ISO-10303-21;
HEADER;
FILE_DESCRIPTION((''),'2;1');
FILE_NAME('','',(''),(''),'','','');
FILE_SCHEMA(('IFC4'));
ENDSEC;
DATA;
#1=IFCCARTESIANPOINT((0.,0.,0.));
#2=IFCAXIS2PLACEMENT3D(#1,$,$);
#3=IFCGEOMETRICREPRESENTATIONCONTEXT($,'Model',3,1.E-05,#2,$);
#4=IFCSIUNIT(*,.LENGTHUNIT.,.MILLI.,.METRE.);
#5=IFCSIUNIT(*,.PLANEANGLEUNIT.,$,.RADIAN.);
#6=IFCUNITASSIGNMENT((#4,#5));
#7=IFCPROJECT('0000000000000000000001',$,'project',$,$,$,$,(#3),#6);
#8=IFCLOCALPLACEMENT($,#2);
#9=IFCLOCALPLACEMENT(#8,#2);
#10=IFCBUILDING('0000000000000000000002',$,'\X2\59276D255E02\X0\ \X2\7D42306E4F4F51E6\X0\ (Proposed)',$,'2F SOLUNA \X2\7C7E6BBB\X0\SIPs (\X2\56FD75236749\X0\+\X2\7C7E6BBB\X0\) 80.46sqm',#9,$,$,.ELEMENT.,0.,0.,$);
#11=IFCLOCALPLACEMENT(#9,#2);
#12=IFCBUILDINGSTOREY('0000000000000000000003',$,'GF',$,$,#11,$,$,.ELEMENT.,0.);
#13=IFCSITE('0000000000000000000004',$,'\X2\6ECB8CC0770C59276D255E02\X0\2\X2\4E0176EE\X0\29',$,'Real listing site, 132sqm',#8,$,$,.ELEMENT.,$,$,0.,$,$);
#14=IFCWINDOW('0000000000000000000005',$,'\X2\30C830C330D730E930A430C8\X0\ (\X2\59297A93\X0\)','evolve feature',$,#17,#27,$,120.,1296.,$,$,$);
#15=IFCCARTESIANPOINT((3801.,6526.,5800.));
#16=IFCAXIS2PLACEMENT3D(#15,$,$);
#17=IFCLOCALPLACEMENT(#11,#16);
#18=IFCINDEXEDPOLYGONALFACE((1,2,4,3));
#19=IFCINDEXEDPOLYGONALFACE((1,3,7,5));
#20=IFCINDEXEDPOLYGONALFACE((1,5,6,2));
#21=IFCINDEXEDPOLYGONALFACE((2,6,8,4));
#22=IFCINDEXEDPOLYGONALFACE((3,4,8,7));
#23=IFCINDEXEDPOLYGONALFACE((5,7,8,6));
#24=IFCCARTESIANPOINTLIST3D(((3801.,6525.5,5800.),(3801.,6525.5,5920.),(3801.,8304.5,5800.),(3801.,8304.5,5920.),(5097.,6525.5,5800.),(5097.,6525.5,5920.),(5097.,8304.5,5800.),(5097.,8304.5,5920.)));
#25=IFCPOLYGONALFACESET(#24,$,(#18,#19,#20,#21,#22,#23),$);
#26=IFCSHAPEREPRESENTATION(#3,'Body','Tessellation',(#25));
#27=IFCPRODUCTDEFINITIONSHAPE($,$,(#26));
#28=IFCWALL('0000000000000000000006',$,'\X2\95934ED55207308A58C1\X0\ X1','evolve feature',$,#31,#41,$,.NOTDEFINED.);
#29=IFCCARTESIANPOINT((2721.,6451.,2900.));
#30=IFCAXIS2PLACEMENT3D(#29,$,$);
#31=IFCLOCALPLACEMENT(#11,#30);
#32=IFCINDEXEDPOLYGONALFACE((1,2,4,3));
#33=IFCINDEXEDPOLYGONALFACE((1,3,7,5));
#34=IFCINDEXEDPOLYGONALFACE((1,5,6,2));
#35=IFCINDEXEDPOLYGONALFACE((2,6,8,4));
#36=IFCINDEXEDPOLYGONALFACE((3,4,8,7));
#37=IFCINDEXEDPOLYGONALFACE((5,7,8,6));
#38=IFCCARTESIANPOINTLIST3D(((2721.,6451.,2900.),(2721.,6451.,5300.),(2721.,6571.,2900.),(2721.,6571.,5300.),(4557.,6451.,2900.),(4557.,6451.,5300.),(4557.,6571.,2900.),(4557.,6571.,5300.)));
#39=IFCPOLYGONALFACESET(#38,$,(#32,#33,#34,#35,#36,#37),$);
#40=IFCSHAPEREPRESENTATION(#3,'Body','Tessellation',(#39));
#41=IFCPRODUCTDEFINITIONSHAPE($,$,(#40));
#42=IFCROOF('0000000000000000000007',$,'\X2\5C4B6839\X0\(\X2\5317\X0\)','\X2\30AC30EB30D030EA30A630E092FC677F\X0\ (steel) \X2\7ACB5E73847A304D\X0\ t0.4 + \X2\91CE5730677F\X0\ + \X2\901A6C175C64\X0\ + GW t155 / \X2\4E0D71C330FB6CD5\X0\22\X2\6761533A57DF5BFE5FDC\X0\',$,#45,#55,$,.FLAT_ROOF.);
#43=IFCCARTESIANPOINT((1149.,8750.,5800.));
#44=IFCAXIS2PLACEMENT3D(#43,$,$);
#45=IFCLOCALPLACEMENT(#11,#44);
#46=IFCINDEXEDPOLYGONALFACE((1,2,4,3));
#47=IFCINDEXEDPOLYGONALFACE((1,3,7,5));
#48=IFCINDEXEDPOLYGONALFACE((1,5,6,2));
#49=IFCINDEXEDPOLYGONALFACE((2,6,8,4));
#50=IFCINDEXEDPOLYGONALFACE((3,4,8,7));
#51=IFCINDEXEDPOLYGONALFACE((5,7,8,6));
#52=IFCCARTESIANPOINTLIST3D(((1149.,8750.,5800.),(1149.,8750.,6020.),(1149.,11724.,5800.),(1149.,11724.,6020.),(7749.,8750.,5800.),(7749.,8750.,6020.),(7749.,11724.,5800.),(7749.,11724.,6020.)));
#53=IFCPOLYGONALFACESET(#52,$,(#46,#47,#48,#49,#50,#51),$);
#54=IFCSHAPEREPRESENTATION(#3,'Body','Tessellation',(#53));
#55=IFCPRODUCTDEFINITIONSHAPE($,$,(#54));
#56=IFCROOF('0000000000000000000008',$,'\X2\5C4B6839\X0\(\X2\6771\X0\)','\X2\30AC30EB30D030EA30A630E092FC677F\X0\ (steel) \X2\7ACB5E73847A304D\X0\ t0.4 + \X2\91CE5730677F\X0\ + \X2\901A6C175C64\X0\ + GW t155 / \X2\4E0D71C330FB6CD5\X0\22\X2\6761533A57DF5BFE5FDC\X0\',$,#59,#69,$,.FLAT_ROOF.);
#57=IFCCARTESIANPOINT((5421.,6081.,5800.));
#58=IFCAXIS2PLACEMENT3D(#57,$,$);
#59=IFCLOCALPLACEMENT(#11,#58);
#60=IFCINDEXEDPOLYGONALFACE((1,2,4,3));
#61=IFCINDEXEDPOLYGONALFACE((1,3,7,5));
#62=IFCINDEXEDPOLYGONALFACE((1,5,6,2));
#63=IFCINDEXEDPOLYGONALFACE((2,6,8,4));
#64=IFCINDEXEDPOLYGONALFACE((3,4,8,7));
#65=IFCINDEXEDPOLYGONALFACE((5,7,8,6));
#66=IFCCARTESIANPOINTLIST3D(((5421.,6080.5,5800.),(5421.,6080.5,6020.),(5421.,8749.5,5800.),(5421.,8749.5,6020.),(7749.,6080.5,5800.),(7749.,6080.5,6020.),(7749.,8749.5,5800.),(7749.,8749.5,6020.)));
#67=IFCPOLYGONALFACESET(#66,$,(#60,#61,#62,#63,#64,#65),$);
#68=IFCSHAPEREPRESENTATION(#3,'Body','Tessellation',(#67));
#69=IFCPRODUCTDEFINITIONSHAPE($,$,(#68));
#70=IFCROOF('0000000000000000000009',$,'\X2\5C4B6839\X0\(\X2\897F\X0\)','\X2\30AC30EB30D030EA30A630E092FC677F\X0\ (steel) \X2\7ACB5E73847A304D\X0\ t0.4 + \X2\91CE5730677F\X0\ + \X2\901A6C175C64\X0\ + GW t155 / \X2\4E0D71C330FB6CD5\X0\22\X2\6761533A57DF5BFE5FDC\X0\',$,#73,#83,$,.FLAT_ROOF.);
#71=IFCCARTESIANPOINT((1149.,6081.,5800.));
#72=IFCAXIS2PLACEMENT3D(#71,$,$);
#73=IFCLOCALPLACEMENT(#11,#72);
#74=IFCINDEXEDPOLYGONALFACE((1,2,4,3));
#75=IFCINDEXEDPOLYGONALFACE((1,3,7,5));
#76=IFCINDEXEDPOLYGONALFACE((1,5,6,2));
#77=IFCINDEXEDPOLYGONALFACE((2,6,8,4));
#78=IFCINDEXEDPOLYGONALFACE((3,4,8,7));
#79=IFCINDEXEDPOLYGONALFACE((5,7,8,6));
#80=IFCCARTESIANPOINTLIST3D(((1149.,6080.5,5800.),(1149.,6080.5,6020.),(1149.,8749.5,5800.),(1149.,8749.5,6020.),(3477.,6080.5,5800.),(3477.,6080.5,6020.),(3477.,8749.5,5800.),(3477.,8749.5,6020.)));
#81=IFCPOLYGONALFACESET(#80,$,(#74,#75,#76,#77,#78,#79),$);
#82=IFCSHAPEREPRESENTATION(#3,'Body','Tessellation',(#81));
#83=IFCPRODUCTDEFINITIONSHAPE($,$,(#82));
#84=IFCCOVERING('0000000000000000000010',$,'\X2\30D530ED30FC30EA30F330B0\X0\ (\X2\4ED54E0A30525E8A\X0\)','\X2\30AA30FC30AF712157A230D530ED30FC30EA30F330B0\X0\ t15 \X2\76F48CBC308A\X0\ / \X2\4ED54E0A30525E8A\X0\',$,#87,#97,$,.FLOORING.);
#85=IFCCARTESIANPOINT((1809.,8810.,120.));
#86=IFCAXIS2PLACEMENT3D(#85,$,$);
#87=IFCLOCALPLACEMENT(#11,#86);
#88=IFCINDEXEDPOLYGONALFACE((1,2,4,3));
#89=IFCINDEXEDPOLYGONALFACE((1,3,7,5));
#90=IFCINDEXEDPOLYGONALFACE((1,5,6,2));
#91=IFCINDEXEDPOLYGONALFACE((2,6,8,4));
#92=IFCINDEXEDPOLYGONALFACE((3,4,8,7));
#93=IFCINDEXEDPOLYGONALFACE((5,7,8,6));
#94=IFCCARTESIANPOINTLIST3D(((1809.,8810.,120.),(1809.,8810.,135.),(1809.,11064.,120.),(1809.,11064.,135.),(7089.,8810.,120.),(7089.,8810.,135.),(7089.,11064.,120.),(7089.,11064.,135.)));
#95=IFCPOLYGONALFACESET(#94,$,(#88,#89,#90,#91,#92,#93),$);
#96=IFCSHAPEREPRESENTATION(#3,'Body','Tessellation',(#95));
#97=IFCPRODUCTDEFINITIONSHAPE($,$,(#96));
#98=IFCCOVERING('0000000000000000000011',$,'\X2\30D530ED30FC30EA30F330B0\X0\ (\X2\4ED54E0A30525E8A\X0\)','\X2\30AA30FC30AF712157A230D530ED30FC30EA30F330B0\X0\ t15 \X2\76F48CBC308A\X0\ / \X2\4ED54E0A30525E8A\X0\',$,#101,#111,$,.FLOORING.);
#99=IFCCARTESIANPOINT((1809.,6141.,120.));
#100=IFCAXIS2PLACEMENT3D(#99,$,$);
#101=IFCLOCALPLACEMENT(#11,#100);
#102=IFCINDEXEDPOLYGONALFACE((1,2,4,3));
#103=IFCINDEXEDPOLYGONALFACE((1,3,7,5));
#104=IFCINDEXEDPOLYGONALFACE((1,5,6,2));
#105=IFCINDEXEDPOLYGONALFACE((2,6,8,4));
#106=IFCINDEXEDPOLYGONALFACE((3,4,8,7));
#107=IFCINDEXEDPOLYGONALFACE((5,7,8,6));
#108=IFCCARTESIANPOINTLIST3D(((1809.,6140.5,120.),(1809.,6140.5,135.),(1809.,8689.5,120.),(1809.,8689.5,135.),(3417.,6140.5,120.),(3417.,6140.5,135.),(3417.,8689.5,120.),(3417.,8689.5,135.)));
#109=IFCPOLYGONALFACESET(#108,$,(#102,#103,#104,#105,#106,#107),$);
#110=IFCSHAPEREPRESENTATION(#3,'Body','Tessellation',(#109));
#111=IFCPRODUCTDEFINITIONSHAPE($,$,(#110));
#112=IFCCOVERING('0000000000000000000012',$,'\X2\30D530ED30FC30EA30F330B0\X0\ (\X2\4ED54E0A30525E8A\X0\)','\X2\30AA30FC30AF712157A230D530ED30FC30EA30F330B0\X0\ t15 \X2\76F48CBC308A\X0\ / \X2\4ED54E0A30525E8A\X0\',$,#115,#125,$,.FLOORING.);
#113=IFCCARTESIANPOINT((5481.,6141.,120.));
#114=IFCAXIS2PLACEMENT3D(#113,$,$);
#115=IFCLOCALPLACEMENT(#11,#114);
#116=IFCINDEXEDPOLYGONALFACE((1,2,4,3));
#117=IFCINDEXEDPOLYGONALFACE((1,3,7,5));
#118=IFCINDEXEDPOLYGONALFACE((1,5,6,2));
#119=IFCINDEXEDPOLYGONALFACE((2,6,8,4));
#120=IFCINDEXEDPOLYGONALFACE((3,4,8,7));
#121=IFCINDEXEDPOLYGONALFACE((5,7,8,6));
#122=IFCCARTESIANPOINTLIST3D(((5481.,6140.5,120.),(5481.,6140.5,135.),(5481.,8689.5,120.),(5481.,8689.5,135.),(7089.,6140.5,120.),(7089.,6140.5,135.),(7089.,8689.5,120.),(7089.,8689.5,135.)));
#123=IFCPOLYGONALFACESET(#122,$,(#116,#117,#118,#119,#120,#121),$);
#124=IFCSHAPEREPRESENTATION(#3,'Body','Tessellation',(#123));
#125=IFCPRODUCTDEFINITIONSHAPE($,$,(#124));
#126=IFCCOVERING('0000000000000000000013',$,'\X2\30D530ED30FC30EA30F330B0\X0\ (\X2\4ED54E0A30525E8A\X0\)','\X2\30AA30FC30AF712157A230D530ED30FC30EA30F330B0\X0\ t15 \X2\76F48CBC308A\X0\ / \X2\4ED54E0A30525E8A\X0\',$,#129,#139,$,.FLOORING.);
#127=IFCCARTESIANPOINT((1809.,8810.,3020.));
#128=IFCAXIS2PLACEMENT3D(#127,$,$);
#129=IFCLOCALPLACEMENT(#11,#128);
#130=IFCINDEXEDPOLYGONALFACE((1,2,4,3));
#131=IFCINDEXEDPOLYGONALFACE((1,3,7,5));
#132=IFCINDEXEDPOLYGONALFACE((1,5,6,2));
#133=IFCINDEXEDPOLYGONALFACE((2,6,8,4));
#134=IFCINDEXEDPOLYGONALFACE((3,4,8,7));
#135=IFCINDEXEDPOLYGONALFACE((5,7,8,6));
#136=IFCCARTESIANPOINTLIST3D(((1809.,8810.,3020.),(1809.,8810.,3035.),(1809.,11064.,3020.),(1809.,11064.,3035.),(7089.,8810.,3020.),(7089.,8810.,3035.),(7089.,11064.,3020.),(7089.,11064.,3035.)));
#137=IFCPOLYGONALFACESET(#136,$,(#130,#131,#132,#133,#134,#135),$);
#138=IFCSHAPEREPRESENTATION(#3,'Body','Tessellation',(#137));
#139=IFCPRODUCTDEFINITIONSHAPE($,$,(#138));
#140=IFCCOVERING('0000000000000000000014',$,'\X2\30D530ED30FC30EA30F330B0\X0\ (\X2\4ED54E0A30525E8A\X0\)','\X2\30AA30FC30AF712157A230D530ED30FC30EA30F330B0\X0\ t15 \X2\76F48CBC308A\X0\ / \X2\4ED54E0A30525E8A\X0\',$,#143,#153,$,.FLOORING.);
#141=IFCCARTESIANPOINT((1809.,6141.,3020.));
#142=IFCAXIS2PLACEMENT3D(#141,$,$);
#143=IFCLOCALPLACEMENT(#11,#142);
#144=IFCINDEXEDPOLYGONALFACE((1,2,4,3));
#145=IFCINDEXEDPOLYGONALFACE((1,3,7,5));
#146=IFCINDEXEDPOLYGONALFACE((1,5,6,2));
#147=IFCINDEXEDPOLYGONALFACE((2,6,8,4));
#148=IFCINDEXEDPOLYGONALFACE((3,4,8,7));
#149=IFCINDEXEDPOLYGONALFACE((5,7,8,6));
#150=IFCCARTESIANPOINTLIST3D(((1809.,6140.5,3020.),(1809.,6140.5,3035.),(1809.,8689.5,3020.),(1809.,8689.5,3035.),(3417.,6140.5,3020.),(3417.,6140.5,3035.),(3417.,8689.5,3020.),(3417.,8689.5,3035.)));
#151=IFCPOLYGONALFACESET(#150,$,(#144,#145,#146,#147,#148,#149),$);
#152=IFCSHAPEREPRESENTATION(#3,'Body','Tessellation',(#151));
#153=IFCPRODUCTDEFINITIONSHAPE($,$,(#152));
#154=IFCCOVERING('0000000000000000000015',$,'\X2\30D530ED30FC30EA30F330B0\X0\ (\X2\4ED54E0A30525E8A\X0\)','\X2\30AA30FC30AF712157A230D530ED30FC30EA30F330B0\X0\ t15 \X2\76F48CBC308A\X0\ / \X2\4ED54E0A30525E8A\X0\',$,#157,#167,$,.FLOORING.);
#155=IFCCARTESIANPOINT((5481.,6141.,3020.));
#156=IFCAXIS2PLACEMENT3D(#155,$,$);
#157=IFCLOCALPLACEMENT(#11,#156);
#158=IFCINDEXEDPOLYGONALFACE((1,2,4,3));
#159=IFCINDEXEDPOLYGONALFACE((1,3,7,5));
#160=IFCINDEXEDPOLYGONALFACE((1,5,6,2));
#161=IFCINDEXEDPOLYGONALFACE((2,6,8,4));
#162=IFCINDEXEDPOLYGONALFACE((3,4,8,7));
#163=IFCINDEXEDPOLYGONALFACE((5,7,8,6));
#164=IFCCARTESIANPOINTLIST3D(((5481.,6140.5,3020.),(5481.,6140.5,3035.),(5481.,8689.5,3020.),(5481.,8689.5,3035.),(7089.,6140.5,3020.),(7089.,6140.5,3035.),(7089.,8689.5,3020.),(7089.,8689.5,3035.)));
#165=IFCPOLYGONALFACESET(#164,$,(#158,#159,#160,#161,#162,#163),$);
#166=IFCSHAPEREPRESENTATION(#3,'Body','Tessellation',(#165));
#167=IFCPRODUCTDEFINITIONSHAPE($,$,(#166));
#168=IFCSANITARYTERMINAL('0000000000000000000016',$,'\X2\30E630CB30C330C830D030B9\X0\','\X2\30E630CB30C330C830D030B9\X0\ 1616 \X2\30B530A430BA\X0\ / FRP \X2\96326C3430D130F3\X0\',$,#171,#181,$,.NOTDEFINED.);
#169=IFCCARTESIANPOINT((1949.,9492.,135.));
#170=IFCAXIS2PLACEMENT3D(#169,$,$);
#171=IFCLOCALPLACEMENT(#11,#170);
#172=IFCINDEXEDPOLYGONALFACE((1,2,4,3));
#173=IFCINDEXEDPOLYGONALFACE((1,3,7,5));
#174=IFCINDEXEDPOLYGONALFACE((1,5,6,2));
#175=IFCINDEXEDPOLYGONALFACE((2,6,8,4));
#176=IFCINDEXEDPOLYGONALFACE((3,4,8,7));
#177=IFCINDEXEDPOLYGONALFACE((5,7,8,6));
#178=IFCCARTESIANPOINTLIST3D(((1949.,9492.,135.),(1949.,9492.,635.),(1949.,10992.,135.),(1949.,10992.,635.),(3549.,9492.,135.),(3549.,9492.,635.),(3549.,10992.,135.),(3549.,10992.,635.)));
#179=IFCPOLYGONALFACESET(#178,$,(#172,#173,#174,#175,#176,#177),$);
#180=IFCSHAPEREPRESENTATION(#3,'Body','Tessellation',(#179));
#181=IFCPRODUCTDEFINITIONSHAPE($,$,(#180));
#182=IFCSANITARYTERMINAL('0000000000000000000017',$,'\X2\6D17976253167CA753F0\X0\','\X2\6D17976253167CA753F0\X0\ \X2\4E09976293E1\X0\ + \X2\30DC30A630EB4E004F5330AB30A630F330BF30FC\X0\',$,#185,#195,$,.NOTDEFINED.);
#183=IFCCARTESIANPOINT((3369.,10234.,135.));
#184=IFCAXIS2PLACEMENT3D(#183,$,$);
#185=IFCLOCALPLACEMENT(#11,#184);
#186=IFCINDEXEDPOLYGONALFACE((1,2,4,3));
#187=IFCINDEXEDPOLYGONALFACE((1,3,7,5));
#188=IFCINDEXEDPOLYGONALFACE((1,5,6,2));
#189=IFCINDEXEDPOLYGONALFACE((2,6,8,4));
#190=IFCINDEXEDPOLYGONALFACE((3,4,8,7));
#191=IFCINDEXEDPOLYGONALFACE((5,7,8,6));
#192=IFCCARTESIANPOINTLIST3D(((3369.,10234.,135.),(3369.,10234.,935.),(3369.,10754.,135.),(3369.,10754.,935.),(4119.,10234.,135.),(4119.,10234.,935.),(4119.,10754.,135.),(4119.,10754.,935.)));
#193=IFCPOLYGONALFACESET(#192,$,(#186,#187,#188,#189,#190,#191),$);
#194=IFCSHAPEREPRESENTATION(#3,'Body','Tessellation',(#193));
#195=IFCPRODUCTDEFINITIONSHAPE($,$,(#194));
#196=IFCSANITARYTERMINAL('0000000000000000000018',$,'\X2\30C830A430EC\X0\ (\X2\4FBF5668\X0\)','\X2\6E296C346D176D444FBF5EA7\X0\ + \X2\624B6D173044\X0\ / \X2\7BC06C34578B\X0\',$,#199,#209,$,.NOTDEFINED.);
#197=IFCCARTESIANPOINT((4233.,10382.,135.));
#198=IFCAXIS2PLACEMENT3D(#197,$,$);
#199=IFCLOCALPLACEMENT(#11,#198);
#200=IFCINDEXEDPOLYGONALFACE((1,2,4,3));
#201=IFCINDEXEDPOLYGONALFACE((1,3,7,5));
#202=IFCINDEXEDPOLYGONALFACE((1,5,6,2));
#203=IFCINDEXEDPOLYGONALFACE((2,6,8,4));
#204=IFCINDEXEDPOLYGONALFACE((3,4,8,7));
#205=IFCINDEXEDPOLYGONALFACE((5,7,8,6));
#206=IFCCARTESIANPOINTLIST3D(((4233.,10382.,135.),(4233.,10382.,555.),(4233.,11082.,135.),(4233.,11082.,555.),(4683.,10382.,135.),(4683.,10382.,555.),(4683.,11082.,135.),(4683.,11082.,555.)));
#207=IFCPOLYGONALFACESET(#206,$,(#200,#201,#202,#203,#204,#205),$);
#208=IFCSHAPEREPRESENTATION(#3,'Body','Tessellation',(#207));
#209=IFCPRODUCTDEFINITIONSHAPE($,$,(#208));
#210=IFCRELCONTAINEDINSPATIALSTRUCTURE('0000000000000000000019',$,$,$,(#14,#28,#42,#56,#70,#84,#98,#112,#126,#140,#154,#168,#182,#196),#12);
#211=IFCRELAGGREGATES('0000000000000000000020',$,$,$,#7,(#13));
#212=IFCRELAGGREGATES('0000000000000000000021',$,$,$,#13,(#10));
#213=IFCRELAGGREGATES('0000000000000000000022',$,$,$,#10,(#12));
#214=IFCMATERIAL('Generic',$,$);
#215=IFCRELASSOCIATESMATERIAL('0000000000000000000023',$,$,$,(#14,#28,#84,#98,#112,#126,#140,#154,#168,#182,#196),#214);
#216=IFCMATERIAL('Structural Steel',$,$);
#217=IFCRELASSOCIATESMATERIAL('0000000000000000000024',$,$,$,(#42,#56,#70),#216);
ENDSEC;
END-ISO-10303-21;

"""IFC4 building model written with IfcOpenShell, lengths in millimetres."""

from ifc_helpers import new_model, si_unit, frame, frame_2d, origin, place, context, project, spatial, rectangle, extrude, material, element, save


model = new_model("IFC4")

# Units and contexts
model_context = context("Model", 3, precision=1e-05, world=origin())
ifc_project = project(units=[si_unit("LENGTHUNIT", "METRE", prefix="MILLI"), si_unit("PLANEANGLEUNIT", "RADIAN")], contexts=[model_context])

# Site, building, storey
site_placement = place(None, origin())
site = spatial("IfcSite", under=ifc_project, at=site_placement, Name="滋賀県大津市2丁目29", ObjectType="Real listing site, 132sqm", CompositionType="ELEMENT", RefElevation=0.0)
building_placement = place(site_placement, origin())
building = spatial("IfcBuilding", under=site, at=building_placement, Name="大津市 終の住処 (Proposed)", ObjectType="2F SOLUNA 籾殻SIPs (国産杉+籾殻) 80.46sqm", CompositionType="ELEMENT", ElevationOfRefHeight=0.0, ElevationOfTerrain=0.0)
storey_placement = place(building_placement, origin())
storey = spatial("IfcBuildingStorey", under=building, at=storey_placement, Name="GF", CompositionType="ELEMENT", Elevation=0.0)

# Window
ifc_material_1 = material(Name="Generic")
window_1_placement = place(storey_placement, frame((3801.0, 6526.0, 5800.0)))
element("IfcWindow", 1, at=window_1_placement, inside=storey, material=ifc_material_1, Name="トップライト (天窓)", Description="evolve feature", OverallHeight=120.0, OverallWidth=1296.0, context=model_context, shape_type="SweptSolid", body=[
    extrude(rectangle(XDim=1296.0, YDim=1779.0, at=frame_2d((648.0, 889.0))), frame((3801.0, 6526.0, 5800.0)), (0.0, 0.0, 1.0), 120.0),
])

# Wall
wall_1_placement = place(storey_placement, frame((2721.0, 6451.0, 2900.0)))
element("IfcWall", 2, at=wall_1_placement, inside=storey, material=ifc_material_1, Name="間仕切り壁 X1", Description="evolve feature", PredefinedType="NOTDEFINED", context=model_context, shape_type="SweptSolid", body=[
    extrude(rectangle(XDim=1836.0, YDim=120.0, at=frame_2d((918.0, 60.0))), frame((2721.0, 6451.0, 2900.0)), (0.0, 0.0, 1.0), 2400.0),
])

# Roofs
ifc_material_2 = material(Name="Structural Steel")
roof_1_placement = place(storey_placement, frame((1149.0, 8750.0, 5800.0)))
element("IfcRoof", 3, at=roof_1_placement, inside=storey, material=ifc_material_2, Name="屋根(北)", Description="ガルバリウム鋼板 (steel) 立平葺き t0.4 + 野地板 + 通気層 + GW t155 / 不燃・法22条区域対応", PredefinedType="FLAT_ROOF", context=model_context, shape_type="SweptSolid", body=[
    extrude(rectangle(XDim=6600.0, YDim=2974.0, at=frame_2d((3300.0, 1487.0))), frame((1149.0, 8750.0, 5800.0)), (0.0, 0.0, 1.0), 220.0),
])
roof_2_placement = place(storey_placement, frame((5421.0, 6081.0, 5800.0)))
element("IfcRoof", 4, at=roof_2_placement, inside=storey, material=ifc_material_2, Name="屋根(東)", Description="ガルバリウム鋼板 (steel) 立平葺き t0.4 + 野地板 + 通気層 + GW t155 / 不燃・法22条区域対応", PredefinedType="FLAT_ROOF", context=model_context, shape_type="SweptSolid", body=[
    extrude(rectangle(XDim=2328.0, YDim=2669.0, at=frame_2d((1164.0, 1334.0))), frame((5421.0, 6081.0, 5800.0)), (0.0, 0.0, 1.0), 220.0),
])
roof_3_placement = place(storey_placement, frame((1149.0, 6081.0, 5800.0)))
element("IfcRoof", 5, at=roof_3_placement, inside=storey, material=ifc_material_2, Name="屋根(西)", Description="ガルバリウム鋼板 (steel) 立平葺き t0.4 + 野地板 + 通気層 + GW t155 / 不燃・法22条区域対応", PredefinedType="FLAT_ROOF", context=model_context, shape_type="SweptSolid", body=[
    extrude(rectangle(XDim=2328.0, YDim=2669.0, at=frame_2d((1164.0, 1334.0))), frame((1149.0, 6081.0, 5800.0)), (0.0, 0.0, 1.0), 220.0),
])

# Coverings
covering_1_placement = place(storey_placement, frame((1809.0, 8810.0, 120.0)))
element("IfcCovering", 6, at=covering_1_placement, inside=storey, material=ifc_material_1, Name="フローリング (仕上げ床)", Description="オーク無垢フローリング t15 直貼り / 仕上げ床", PredefinedType="FLOORING", context=model_context, shape_type="SweptSolid", body=[
    extrude(rectangle(XDim=5280.0, YDim=2254.0, at=frame_2d((2640.0, 1127.0))), frame((1809.0, 8810.0, 120.0)), (0.0, 0.0, 1.0), 15.0),
])
covering_2_placement = place(storey_placement, frame((1809.0, 6141.0, 120.0)))
element("IfcCovering", 7, at=covering_2_placement, inside=storey, material=ifc_material_1, Name="フローリング (仕上げ床)", Description="オーク無垢フローリング t15 直貼り / 仕上げ床", PredefinedType="FLOORING", context=model_context, shape_type="SweptSolid", body=[
    extrude(rectangle(XDim=1608.0, YDim=2549.0, at=frame_2d((804.0, 1274.0))), frame((1809.0, 6141.0, 120.0)), (0.0, 0.0, 1.0), 15.0),
])
covering_3_placement = place(storey_placement, frame((5481.0, 6141.0, 120.0)))
element("IfcCovering", 8, at=covering_3_placement, inside=storey, material=ifc_material_1, Name="フローリング (仕上げ床)", Description="オーク無垢フローリング t15 直貼り / 仕上げ床", PredefinedType="FLOORING", context=model_context, shape_type="SweptSolid", body=[
    extrude(rectangle(XDim=1608.0, YDim=2549.0, at=frame_2d((804.0, 1274.0))), frame((5481.0, 6141.0, 120.0)), (0.0, 0.0, 1.0), 15.0),
])
covering_4_placement = place(storey_placement, frame((1809.0, 8810.0, 3020.0)))
element("IfcCovering", 9, at=covering_4_placement, inside=storey, material=ifc_material_1, Name="フローリング (仕上げ床)", Description="オーク無垢フローリング t15 直貼り / 仕上げ床", PredefinedType="FLOORING", context=model_context, shape_type="SweptSolid", body=[
    extrude(rectangle(XDim=5280.0, YDim=2254.0, at=frame_2d((2640.0, 1127.0))), frame((1809.0, 8810.0, 3020.0)), (0.0, 0.0, 1.0), 15.0),
])
covering_5_placement = place(storey_placement, frame((1809.0, 6141.0, 3020.0)))
element("IfcCovering", 10, at=covering_5_placement, inside=storey, material=ifc_material_1, Name="フローリング (仕上げ床)", Description="オーク無垢フローリング t15 直貼り / 仕上げ床", PredefinedType="FLOORING", context=model_context, shape_type="SweptSolid", body=[
    extrude(rectangle(XDim=1608.0, YDim=2549.0, at=frame_2d((804.0, 1274.0))), frame((1809.0, 6141.0, 3020.0)), (0.0, 0.0, 1.0), 15.0),
])
covering_6_placement = place(storey_placement, frame((5481.0, 6141.0, 3020.0)))
element("IfcCovering", 11, at=covering_6_placement, inside=storey, material=ifc_material_1, Name="フローリング (仕上げ床)", Description="オーク無垢フローリング t15 直貼り / 仕上げ床", PredefinedType="FLOORING", context=model_context, shape_type="SweptSolid", body=[
    extrude(rectangle(XDim=1608.0, YDim=2549.0, at=frame_2d((804.0, 1274.0))), frame((5481.0, 6141.0, 3020.0)), (0.0, 0.0, 1.0), 15.0),
])

# Sanitary terminals
sanitary_terminal_1_placement = place(storey_placement, frame((1949.0, 9492.0, 135.0)))
element("IfcSanitaryTerminal", 12, at=sanitary_terminal_1_placement, inside=storey, material=ifc_material_1, Name="ユニットバス", Description="ユニットバス 1616 サイズ / FRP 防水パン", PredefinedType="NOTDEFINED", context=model_context, shape_type="SweptSolid", body=[
    extrude(rectangle(XDim=1600.0, YDim=1500.0, at=frame_2d((800.0, 750.0))), frame((1949.0, 9492.0, 135.0)), (0.0, 0.0, 1.0), 500.0),
])
sanitary_terminal_2_placement = place(storey_placement, frame((3369.0, 10234.0, 135.0)))
element("IfcSanitaryTerminal", 13, at=sanitary_terminal_2_placement, inside=storey, material=ifc_material_1, Name="洗面化粧台", Description="洗面化粧台 三面鏡 + ボウル一体カウンター", PredefinedType="NOTDEFINED", context=model_context, shape_type="SweptSolid", body=[
    extrude(rectangle(XDim=750.0, YDim=520.0, at=frame_2d((375.0, 260.0))), frame((3369.0, 10234.0, 135.0)), (0.0, 0.0, 1.0), 800.0),
])
sanitary_terminal_3_placement = place(storey_placement, frame((4233.0, 10382.0, 135.0)))
element("IfcSanitaryTerminal", 14, at=sanitary_terminal_3_placement, inside=storey, material=ifc_material_1, Name="トイレ (便器)", Description="温水洗浄便座 + 手洗い / 節水型", PredefinedType="NOTDEFINED", context=model_context, shape_type="SweptSolid", body=[
    extrude(rectangle(XDim=450.0, YDim=700.0, at=frame_2d((225.0, 350.0))), frame((4233.0, 10382.0, 135.0)), (0.0, 0.0, 1.0), 420.0),
])

save(model, "model.ifc")
